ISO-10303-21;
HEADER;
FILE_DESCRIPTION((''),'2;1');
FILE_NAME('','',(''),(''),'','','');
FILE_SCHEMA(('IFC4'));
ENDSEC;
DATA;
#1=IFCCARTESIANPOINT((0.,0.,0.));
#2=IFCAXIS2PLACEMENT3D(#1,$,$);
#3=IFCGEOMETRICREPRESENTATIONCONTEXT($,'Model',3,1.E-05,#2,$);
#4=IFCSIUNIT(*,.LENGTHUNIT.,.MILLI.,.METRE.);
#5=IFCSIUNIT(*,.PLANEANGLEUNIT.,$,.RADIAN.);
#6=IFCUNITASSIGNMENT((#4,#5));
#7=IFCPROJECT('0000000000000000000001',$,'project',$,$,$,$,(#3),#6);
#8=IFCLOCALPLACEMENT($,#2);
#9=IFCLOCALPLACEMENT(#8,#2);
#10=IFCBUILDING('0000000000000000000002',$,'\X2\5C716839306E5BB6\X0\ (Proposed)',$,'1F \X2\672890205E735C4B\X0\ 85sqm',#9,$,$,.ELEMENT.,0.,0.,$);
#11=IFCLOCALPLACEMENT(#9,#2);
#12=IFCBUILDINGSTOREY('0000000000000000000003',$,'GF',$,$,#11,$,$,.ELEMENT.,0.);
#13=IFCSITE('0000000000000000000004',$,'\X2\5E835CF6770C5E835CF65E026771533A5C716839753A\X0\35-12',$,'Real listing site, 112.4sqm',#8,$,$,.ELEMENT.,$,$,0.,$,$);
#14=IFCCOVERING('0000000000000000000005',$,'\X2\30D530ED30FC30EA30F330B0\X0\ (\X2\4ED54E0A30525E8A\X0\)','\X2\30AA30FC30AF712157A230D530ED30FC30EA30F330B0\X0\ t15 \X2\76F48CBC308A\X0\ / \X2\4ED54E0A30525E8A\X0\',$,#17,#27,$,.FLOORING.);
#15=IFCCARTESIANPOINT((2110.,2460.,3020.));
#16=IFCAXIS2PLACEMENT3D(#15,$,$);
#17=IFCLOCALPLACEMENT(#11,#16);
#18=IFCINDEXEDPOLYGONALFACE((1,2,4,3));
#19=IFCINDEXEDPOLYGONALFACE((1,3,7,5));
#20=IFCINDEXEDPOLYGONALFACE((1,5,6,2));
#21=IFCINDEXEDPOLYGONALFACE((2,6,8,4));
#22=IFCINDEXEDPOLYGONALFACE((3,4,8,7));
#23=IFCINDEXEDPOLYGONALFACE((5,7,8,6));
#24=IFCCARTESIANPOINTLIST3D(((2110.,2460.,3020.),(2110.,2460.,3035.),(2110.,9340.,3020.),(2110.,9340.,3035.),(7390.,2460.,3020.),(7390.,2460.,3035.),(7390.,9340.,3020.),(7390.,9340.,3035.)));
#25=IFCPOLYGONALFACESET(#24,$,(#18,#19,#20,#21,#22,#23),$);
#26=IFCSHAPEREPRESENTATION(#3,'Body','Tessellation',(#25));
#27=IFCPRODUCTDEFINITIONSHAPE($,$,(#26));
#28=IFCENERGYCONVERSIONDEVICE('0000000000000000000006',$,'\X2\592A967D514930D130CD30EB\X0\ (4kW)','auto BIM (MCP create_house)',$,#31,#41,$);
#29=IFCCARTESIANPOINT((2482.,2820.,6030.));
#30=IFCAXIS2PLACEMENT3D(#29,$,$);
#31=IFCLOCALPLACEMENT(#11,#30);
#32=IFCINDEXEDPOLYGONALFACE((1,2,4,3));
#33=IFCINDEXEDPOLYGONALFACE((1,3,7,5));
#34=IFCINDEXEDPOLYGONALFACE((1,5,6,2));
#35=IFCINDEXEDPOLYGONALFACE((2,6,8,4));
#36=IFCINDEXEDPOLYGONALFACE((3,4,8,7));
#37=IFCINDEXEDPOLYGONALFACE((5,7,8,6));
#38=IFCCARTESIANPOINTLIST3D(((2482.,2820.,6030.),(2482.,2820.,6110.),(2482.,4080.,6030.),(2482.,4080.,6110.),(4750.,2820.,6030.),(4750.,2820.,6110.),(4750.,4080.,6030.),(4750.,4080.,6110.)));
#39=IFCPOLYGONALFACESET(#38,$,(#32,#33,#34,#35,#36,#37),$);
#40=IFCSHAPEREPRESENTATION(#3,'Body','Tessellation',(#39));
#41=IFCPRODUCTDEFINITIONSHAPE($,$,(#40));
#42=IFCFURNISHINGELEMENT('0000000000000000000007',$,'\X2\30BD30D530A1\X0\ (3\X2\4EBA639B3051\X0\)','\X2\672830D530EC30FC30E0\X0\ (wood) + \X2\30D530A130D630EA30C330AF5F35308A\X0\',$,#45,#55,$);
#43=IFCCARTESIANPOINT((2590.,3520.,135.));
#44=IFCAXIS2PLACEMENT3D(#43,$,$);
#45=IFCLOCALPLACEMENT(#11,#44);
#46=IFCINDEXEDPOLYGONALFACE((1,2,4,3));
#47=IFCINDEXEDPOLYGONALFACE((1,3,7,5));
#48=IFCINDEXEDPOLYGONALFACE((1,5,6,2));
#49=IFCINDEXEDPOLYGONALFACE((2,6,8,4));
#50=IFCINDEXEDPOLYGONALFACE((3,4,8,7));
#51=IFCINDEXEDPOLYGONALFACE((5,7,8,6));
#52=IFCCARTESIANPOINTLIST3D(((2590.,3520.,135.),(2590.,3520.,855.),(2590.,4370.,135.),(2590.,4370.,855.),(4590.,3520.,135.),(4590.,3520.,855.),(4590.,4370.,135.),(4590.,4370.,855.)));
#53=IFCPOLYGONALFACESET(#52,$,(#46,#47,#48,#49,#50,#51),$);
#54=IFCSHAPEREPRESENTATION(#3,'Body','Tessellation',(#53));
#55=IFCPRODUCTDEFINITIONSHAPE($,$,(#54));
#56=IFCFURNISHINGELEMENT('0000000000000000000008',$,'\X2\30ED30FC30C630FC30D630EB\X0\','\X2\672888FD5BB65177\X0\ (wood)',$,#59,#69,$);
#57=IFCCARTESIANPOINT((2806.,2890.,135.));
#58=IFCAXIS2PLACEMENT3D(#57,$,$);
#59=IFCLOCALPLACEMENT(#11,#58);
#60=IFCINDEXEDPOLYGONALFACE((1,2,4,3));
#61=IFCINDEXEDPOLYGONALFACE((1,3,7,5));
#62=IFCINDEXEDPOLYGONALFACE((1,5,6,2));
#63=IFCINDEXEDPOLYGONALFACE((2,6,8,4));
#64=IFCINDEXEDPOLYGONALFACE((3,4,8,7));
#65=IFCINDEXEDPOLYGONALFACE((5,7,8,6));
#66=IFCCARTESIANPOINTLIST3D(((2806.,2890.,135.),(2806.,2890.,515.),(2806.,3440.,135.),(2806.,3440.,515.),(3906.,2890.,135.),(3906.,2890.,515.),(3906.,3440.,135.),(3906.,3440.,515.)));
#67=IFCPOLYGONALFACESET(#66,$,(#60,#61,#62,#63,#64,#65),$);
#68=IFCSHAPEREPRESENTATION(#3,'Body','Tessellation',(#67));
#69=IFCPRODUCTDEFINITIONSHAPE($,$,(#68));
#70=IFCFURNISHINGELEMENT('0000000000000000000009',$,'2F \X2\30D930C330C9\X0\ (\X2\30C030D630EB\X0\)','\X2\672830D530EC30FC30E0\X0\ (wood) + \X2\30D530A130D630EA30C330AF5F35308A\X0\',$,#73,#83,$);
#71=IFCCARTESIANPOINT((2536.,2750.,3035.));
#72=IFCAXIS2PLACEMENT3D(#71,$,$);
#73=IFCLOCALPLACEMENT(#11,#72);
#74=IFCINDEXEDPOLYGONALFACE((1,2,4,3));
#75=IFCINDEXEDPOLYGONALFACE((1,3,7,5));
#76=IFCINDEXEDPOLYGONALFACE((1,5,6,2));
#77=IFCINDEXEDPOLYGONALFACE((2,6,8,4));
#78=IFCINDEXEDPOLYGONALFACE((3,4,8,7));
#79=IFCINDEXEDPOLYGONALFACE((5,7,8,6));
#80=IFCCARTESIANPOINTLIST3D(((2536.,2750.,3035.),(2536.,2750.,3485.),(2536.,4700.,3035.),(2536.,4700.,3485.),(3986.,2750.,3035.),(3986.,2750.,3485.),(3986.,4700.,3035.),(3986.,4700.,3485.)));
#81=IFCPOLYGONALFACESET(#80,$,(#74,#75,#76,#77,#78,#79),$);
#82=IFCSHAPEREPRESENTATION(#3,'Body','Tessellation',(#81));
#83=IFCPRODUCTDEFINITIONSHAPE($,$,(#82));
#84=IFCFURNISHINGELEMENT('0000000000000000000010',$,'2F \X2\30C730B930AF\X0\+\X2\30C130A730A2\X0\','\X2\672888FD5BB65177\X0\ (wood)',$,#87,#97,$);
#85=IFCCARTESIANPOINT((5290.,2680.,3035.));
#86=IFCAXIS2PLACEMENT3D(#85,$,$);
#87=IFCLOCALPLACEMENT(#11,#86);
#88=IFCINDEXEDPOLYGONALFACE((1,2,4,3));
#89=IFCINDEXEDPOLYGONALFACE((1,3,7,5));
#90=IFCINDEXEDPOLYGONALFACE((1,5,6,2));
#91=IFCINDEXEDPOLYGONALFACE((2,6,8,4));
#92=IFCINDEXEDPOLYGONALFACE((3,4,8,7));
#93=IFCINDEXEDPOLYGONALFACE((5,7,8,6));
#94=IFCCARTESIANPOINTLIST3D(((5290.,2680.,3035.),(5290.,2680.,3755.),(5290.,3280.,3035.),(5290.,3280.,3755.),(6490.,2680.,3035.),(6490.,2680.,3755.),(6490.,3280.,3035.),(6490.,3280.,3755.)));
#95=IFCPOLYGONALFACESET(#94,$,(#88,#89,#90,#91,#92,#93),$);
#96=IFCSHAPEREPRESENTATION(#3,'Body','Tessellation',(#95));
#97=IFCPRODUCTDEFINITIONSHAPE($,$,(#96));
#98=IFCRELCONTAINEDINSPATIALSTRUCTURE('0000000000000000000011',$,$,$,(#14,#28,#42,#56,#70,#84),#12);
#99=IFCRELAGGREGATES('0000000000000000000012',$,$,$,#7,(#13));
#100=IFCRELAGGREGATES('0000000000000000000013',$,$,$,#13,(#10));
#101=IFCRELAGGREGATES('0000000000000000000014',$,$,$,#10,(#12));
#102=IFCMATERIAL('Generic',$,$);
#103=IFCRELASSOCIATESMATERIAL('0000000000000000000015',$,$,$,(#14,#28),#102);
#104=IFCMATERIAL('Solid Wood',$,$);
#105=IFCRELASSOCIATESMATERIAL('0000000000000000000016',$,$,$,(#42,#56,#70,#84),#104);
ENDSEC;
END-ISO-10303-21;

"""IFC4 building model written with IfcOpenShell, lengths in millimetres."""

from ifc_helpers import new_model, si_unit, frame, frame_2d, origin, place, context, project, spatial, rectangle, extrude, material, element, save


model = new_model("IFC4")

# Units and contexts
model_context = context("Model", 3, precision=1e-05, world=origin())
ifc_project = project(units=[si_unit("LENGTHUNIT", "METRE", prefix="MILLI"), si_unit("PLANEANGLEUNIT", "RADIAN")], contexts=[model_context])

# Site, building, storey
site_placement = place(None, origin())
site = spatial("IfcSite", under=ifc_project, at=site_placement, Name="広島県広島市東区山根町35-12", ObjectType="Real listing site, 112.4sqm", CompositionType="ELEMENT", RefElevation=0.0)
building_placement = place(site_placement, origin())
building = spatial("IfcBuilding", under=site, at=building_placement, Name="山根の家 (Proposed)", ObjectType="1F 木造平屋 85sqm", CompositionType="ELEMENT", ElevationOfRefHeight=0.0, ElevationOfTerrain=0.0)
storey_placement = place(building_placement, origin())
storey = spatial("IfcBuildingStorey", under=building, at=storey_placement, Name="GF", CompositionType="ELEMENT", Elevation=0.0)

# Shared definitions
ifc_material_1 = material(Name="Solid Wood")

# Shared definitions
ifc_material_2 = material(Name="Generic")

# Covering
covering_placement = place(storey_placement, frame((2110.0, 2460.0, 3020.0)))
element("IfcCovering", 1, at=covering_placement, inside=storey, material=ifc_material_2, Name="フローリング (仕上げ床)", Description="オーク無垢フローリング t15 直貼り / 仕上げ床", PredefinedType="FLOORING", context=model_context, shape_type="SweptSolid", body=[
    extrude(rectangle(XDim=5280.0, YDim=6880.0, at=frame_2d((2640.0, 3440.0))), frame((2110.0, 2460.0, 3020.0)), (0.0, 0.0, 1.0), 15.0),
])

# Energy conversion device
energy_conversion_device_placement = place(storey_placement, frame((2482.0, 2820.0, 6030.0)))
element("IfcEnergyConversionDevice", 2, at=energy_conversion_device_placement, inside=storey, material=ifc_material_2, Name="太陽光パネル (4kW)", Description="auto BIM (MCP create_house)", context=model_context, shape_type="SweptSolid", body=[
    extrude(rectangle(XDim=2268.0, YDim=1260.0, at=frame_2d((1134.0, 630.0))), frame((2482.0, 2820.0, 6030.0)), (0.0, 0.0, 1.0), 80.0),
])

# Furnishing elements
furnishing_1_placement = place(storey_placement, frame((2590.0, 3520.0, 135.0)))
element("IfcFurnishingElement", 3, at=furnishing_1_placement, inside=storey, material=ifc_material_1, Name="ソファ (3人掛け)", Description="木フレーム (wood) + ファブリック張り", context=model_context, shape_type="SweptSolid", body=[
    extrude(rectangle(XDim=2000.0, YDim=850.0, at=frame_2d((1000.0, 425.0))), frame((2590.0, 3520.0, 135.0)), (0.0, 0.0, 1.0), 720.0),
])
furnishing_2_placement = place(storey_placement, frame((2806.0, 2890.0, 135.0)))
element("IfcFurnishingElement", 4, at=furnishing_2_placement, inside=storey, material=ifc_material_1, Name="ローテーブル", Description="木製家具 (wood)", context=model_context, shape_type="SweptSolid", body=[
    extrude(rectangle(XDim=1100.0, YDim=550.0, at=frame_2d((550.0, 275.0))), frame((2806.0, 2890.0, 135.0)), (0.0, 0.0, 1.0), 380.0),
])
furnishing_3_placement = place(storey_placement, frame((2536.0, 2750.0, 3035.0)))
element("IfcFurnishingElement", 5, at=furnishing_3_placement, inside=storey, material=ifc_material_1, Name="2F ベッド (ダブル)", Description="木フレーム (wood) + ファブリック張り", context=model_context, shape_type="SweptSolid", body=[
    extrude(rectangle(XDim=1450.0, YDim=1950.0, at=frame_2d((725.0, 975.0))), frame((2536.0, 2750.0, 3035.0)), (0.0, 0.0, 1.0), 450.0),
])
furnishing_4_placement = place(storey_placement, frame((5290.0, 2680.0, 3035.0)))
element("IfcFurnishingElement", 6, at=furnishing_4_placement, inside=storey, material=ifc_material_1, Name="2F デスク+チェア", Description="木製家具 (wood)", context=model_context, shape_type="SweptSolid", body=[
    extrude(rectangle(XDim=1200.0, YDim=600.0, at=frame_2d((600.0, 300.0))), frame((5290.0, 2680.0, 3035.0)), (0.0, 0.0, 1.0), 720.0),
])

save(model, "model.ifc")
